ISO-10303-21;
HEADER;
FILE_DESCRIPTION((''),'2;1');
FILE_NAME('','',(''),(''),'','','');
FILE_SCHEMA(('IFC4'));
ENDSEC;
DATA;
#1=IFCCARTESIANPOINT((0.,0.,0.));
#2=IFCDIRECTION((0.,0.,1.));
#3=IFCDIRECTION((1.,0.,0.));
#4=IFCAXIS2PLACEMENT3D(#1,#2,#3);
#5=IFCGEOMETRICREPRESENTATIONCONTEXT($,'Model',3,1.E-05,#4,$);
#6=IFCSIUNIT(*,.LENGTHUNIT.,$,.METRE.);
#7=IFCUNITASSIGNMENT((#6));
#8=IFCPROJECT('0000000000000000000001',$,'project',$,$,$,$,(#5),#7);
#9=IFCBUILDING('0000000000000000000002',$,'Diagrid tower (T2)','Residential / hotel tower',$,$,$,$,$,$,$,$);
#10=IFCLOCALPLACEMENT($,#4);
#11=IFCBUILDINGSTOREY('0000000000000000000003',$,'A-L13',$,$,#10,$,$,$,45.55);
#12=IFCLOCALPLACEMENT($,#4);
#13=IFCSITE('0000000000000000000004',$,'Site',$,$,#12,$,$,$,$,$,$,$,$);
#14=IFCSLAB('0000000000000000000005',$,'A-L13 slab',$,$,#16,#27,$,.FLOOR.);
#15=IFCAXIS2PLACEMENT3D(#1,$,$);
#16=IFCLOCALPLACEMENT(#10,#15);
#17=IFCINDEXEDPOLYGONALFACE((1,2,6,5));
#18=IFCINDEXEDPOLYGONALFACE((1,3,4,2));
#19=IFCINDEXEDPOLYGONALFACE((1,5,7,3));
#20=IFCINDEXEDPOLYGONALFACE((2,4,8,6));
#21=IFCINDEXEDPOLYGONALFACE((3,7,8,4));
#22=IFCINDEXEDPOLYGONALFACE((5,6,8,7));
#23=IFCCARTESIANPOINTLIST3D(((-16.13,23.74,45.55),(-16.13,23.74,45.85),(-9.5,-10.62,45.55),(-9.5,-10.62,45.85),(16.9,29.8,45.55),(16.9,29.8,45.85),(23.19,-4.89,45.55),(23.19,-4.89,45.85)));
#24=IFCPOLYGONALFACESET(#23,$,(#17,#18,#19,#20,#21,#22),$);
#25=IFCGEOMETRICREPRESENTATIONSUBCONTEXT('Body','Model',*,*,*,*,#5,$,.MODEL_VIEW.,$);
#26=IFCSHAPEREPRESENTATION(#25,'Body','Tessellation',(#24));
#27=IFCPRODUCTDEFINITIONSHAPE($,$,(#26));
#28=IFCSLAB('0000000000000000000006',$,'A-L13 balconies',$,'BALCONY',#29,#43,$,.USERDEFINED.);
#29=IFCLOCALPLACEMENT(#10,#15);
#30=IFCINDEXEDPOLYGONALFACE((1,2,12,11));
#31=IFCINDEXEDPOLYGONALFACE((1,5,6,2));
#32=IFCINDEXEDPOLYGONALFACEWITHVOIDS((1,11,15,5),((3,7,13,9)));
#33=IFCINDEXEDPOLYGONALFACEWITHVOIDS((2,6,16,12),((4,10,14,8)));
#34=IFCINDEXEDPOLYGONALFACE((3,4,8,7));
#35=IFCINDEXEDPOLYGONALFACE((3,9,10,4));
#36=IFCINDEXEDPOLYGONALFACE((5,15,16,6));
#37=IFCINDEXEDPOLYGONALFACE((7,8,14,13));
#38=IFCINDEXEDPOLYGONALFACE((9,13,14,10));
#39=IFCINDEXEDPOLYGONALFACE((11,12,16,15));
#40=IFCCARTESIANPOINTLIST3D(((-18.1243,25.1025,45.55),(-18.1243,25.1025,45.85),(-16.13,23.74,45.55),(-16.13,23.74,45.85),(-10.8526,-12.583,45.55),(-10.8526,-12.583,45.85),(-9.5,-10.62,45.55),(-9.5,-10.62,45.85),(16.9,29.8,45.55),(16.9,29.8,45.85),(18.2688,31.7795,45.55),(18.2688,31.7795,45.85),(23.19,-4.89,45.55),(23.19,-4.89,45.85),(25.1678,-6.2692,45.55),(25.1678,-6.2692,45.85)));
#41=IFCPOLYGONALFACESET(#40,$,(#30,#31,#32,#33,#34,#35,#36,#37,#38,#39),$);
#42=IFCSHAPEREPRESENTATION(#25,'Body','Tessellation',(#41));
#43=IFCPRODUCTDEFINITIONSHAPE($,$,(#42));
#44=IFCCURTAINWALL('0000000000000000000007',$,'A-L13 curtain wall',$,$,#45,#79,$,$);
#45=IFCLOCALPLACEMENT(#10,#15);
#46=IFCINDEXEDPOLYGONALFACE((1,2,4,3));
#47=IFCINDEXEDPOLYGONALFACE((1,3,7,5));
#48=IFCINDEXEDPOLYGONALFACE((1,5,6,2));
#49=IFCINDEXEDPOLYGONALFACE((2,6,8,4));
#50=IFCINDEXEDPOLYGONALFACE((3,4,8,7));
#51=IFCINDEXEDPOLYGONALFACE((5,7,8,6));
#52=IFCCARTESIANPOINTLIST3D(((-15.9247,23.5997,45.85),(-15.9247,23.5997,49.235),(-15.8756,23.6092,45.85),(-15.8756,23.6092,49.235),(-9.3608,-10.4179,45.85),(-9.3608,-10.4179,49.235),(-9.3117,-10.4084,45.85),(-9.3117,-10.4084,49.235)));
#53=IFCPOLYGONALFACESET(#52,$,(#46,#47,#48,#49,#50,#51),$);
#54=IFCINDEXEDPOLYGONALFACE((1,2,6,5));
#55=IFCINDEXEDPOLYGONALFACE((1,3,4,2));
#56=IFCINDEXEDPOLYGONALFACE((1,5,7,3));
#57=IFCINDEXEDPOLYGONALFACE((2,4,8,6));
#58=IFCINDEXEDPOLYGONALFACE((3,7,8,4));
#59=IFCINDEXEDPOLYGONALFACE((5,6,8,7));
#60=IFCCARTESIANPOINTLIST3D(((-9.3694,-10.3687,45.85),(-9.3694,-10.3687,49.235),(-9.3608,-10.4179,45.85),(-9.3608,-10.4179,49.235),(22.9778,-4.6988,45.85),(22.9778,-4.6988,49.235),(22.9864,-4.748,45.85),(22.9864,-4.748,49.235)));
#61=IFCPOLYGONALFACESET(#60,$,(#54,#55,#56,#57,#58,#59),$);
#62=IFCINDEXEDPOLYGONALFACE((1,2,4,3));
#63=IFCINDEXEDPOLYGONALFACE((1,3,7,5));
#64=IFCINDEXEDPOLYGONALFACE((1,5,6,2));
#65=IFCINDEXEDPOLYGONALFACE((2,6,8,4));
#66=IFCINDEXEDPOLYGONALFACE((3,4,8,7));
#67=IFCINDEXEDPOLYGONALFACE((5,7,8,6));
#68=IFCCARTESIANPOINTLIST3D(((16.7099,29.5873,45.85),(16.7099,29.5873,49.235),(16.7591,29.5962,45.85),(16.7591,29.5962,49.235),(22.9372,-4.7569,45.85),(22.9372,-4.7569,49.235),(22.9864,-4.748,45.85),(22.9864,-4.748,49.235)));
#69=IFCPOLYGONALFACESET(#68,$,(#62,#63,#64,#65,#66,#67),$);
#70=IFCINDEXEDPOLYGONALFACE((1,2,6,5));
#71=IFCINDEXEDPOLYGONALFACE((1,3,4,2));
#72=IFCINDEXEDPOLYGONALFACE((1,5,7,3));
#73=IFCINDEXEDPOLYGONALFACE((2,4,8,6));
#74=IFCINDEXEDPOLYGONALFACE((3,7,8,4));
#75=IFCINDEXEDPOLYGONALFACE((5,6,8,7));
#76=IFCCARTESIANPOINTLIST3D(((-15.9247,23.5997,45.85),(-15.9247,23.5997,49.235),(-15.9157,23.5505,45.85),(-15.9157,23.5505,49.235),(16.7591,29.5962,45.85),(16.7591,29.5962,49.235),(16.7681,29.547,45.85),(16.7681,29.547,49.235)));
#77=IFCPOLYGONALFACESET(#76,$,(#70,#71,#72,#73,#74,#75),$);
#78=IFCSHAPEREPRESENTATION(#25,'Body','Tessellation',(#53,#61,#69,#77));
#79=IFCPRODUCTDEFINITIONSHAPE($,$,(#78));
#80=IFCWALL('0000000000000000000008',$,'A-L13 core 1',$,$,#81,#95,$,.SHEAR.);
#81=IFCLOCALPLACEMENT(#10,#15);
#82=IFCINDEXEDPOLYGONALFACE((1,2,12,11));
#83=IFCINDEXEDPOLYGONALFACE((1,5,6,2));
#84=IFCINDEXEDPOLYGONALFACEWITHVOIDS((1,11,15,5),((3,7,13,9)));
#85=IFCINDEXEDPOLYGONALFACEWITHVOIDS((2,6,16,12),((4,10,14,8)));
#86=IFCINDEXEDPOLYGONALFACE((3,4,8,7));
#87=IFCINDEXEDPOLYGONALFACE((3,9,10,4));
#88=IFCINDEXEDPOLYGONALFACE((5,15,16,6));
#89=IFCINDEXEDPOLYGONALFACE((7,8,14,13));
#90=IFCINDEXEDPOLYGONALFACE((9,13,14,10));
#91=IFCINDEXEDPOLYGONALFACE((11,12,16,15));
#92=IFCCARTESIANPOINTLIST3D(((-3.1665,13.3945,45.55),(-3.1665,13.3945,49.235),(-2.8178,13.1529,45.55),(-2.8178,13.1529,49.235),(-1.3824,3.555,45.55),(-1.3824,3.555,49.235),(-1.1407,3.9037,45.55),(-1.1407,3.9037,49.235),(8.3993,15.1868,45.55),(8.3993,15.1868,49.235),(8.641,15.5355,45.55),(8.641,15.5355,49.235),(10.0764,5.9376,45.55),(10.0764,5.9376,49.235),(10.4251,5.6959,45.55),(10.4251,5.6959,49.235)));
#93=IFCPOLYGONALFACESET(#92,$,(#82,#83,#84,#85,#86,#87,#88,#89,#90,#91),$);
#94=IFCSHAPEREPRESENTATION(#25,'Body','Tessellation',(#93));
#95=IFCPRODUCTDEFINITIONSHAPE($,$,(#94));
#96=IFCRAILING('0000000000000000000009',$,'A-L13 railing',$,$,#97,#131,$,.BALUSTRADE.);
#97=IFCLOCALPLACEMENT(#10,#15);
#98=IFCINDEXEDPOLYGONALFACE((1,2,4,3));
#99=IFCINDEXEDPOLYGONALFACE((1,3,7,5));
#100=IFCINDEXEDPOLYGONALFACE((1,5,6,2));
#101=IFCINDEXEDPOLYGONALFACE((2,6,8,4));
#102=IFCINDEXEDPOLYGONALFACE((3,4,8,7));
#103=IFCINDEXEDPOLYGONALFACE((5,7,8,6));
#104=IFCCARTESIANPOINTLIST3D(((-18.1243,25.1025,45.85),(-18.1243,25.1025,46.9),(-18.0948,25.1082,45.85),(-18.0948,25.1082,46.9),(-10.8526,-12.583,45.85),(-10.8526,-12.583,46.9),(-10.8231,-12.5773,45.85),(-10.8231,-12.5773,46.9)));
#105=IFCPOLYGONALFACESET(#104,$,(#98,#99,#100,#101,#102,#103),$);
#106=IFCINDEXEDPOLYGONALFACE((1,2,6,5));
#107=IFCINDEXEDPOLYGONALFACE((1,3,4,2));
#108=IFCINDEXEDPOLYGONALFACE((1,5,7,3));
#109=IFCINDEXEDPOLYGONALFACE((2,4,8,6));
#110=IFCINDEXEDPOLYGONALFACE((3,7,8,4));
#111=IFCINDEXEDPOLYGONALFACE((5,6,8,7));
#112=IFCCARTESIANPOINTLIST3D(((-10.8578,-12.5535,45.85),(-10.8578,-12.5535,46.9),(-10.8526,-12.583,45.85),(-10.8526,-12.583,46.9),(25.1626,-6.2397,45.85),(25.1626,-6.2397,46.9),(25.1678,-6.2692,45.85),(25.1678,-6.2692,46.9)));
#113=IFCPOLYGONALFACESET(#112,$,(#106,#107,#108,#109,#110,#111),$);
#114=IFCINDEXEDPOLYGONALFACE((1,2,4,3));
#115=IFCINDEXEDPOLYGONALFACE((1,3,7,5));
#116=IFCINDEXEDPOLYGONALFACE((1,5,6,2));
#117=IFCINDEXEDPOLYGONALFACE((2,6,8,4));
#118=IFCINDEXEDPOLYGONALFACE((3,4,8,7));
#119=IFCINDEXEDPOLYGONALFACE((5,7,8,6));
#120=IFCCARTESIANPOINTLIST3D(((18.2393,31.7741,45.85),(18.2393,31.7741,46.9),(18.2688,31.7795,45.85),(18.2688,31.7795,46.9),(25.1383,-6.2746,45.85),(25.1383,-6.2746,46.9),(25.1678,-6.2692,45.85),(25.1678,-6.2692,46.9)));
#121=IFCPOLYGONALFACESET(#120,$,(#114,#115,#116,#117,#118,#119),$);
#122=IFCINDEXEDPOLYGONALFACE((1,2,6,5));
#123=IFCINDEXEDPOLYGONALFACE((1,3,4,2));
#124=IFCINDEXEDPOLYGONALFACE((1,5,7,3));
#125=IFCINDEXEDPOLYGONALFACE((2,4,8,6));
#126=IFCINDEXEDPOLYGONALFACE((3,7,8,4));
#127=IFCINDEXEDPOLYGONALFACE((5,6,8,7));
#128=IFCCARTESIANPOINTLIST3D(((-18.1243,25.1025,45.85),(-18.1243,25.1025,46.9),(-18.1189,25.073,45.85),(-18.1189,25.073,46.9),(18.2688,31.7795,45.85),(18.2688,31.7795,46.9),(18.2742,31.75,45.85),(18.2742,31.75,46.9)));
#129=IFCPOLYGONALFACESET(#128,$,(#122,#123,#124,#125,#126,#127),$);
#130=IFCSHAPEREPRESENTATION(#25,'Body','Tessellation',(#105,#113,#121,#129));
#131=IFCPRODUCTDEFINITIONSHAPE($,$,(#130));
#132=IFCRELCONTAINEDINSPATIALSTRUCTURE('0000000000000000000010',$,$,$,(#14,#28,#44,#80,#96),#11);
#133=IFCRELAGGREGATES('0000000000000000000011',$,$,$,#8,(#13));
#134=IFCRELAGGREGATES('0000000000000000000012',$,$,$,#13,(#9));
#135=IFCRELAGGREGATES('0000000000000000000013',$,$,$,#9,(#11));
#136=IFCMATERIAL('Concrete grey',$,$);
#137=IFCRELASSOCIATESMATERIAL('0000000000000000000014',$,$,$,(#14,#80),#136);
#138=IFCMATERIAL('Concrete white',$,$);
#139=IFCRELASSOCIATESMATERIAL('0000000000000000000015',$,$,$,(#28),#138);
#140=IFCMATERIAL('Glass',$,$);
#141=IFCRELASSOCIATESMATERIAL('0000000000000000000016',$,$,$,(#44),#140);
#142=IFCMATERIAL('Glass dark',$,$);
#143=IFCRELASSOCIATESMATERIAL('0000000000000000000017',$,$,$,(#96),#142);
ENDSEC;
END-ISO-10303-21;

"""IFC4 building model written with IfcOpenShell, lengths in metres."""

from ifc_helpers import new_model, si_unit, frame, origin_with_axes, place, context, subcontext, project, spatial, polyline, outline, extrude, material, element, save


model = new_model("IFC4")

# Units and contexts
model_context = context("Model", 3, precision=1e-05, world=origin_with_axes())
body_context = subcontext(model_context, "Body", "Model", "MODEL_VIEW")
ifc_project = project(units=[si_unit("LENGTHUNIT", "METRE")], contexts=[model_context])

# Site, building, storey
site_placement = place(None, origin_with_axes())
site = spatial("IfcSite", under=ifc_project, at=site_placement, Name="Site")
building = spatial("IfcBuilding", under=site, Name="Diagrid tower (T2)", Description="Residential / hotel tower")
storey_placement = place(None, origin_with_axes())
storey = spatial("IfcBuildingStorey", under=building, at=storey_placement, Name="A-L13", Elevation=45.55)

# Slabs
ifc_material_1 = material(Name="Concrete grey")
slab_1_placement = place(storey_placement, origin_with_axes())
element("IfcSlab", 1, at=slab_1_placement, inside=storey, material=ifc_material_1, Name="A-L13 slab", PredefinedType="FLOOR", context=body_context, shape_type="SweptSolid", body=[
    extrude(outline(polyline([(-16.13, 23.74), (-9.5, -10.62), (23.19, -4.89), (16.9, 29.8), (-16.13, 23.74)])), frame((0.0, 0.0, 45.55), z_axis=(0.0, 0.0, 1.0), x_axis=(1.0, 0.0, 0.0)), (0.0, 0.0, 1.0), 0.3),
])
ifc_material_2 = material(Name="Concrete white")
slab_2_placement = place(storey_placement, origin_with_axes())
element("IfcSlab", 2, at=slab_2_placement, inside=storey, material=ifc_material_2, Name="A-L13 balconies", ObjectType="BALCONY", PredefinedType="USERDEFINED", context=body_context, shape_type="SweptSolid", body=[
    extrude(outline(polyline([(-18.1243, 25.1025), (-10.8526, -12.583), (25.1678, -6.2692), (18.2688, 31.7795), (-18.1243, 25.1025)]), holes=[polyline([(-16.13, 23.74), (-9.5, -10.62), (23.19, -4.89), (16.9, 29.8), (-16.13, 23.74)])]), frame((0.0, 0.0, 45.55), z_axis=(0.0, 0.0, 1.0), x_axis=(1.0, 0.0, 0.0)), (0.0, 0.0, 1.0), 0.3),
])

# Curtain wall
ifc_material_3 = material(Name="Glass")
curtain_wall_placement = place(storey_placement, origin_with_axes())
element("IfcCurtainWall", 3, at=curtain_wall_placement, inside=storey, material=ifc_material_3, Name="A-L13 curtain wall", context=body_context, shape_type="SweptSolid", body=[
    extrude(outline(polyline([(-15.9247, 23.5997), (-9.3608, -10.4179), (-9.3117, -10.4084), (-15.8756, 23.6092), (-15.9247, 23.5997)])), frame((0.0, 0.0, 45.85), z_axis=(0.0, 0.0, 1.0), x_axis=(1.0, 0.0, 0.0)), (0.0, 0.0, 1.0), 3.385),
    extrude(outline(polyline([(-9.3608, -10.4179), (22.9864, -4.748), (22.9778, -4.6988), (-9.3694, -10.3687), (-9.3608, -10.4179)])), frame((0.0, 0.0, 45.85), z_axis=(0.0, 0.0, 1.0), x_axis=(1.0, 0.0, 0.0)), (0.0, 0.0, 1.0), 3.385),
    extrude(outline(polyline([(22.9864, -4.748), (16.7591, 29.5962), (16.7099, 29.5873), (22.9372, -4.7569), (22.9864, -4.748)])), frame((0.0, 0.0, 45.85), z_axis=(0.0, 0.0, 1.0), x_axis=(1.0, 0.0, 0.0)), (0.0, 0.0, 1.0), 3.385),
    extrude(outline(polyline([(16.7591, 29.5962), (-15.9247, 23.5997), (-15.9157, 23.5505), (16.7681, 29.547), (16.7591, 29.5962)])), frame((0.0, 0.0, 45.85), z_axis=(0.0, 0.0, 1.0), x_axis=(1.0, 0.0, 0.0)), (0.0, 0.0, 1.0), 3.385),
])

# Wall
wall_placement = place(storey_placement, origin_with_axes())
element("IfcWall", 4, at=wall_placement, inside=storey, material=ifc_material_1, Name="A-L13 core 1", PredefinedType="SHEAR", context=body_context, shape_type="SweptSolid", body=[
    extrude(outline(polyline([(10.4251, 5.6959), (8.641, 15.5355), (-3.1665, 13.3945), (-1.3824, 3.555), (10.4251, 5.6959)]), holes=[polyline([(10.0764, 5.9376), (8.3993, 15.1868), (-2.8178, 13.1529), (-1.1407, 3.9037), (10.0764, 5.9376)])]), frame((0.0, 0.0, 45.55), z_axis=(0.0, 0.0, 1.0), x_axis=(1.0, 0.0, 0.0)), (0.0, 0.0, 1.0), 3.685),
])

# Railing
ifc_material_4 = material(Name="Glass dark")
railing_placement = place(storey_placement, origin_with_axes())
element("IfcRailing", 5, at=railing_placement, inside=storey, material=ifc_material_4, Name="A-L13 railing", PredefinedType="BALUSTRADE", context=body_context, shape_type="SweptSolid", body=[
    extrude(outline(polyline([(-18.1243, 25.1025), (-10.8526, -12.583), (-10.8231, -12.5773), (-18.0948, 25.1082), (-18.1243, 25.1025)])), frame((0.0, 0.0, 45.85), z_axis=(0.0, 0.0, 1.0), x_axis=(1.0, 0.0, 0.0)), (0.0, 0.0, 1.0), 1.05),
    extrude(outline(polyline([(-10.8526, -12.583), (25.1678, -6.2692), (25.1626, -6.2397), (-10.8578, -12.5535), (-10.8526, -12.583)])), frame((0.0, 0.0, 45.85), z_axis=(0.0, 0.0, 1.0), x_axis=(1.0, 0.0, 0.0)), (0.0, 0.0, 1.0), 1.05),
    extrude(outline(polyline([(25.1678, -6.2692), (18.2688, 31.7795), (18.2393, 31.7741), (25.1383, -6.2746), (25.1678, -6.2692)])), frame((0.0, 0.0, 45.85), z_axis=(0.0, 0.0, 1.0), x_axis=(1.0, 0.0, 0.0)), (0.0, 0.0, 1.0), 1.05),
    extrude(outline(polyline([(18.2688, 31.7795), (-18.1243, 25.1025), (-18.1189, 25.073), (18.2742, 31.75), (18.2688, 31.7795)])), frame((0.0, 0.0, 45.85), z_axis=(0.0, 0.0, 1.0), x_axis=(1.0, 0.0, 0.0)), (0.0, 0.0, 1.0), 1.05),
])

save(model, "model.ifc")
